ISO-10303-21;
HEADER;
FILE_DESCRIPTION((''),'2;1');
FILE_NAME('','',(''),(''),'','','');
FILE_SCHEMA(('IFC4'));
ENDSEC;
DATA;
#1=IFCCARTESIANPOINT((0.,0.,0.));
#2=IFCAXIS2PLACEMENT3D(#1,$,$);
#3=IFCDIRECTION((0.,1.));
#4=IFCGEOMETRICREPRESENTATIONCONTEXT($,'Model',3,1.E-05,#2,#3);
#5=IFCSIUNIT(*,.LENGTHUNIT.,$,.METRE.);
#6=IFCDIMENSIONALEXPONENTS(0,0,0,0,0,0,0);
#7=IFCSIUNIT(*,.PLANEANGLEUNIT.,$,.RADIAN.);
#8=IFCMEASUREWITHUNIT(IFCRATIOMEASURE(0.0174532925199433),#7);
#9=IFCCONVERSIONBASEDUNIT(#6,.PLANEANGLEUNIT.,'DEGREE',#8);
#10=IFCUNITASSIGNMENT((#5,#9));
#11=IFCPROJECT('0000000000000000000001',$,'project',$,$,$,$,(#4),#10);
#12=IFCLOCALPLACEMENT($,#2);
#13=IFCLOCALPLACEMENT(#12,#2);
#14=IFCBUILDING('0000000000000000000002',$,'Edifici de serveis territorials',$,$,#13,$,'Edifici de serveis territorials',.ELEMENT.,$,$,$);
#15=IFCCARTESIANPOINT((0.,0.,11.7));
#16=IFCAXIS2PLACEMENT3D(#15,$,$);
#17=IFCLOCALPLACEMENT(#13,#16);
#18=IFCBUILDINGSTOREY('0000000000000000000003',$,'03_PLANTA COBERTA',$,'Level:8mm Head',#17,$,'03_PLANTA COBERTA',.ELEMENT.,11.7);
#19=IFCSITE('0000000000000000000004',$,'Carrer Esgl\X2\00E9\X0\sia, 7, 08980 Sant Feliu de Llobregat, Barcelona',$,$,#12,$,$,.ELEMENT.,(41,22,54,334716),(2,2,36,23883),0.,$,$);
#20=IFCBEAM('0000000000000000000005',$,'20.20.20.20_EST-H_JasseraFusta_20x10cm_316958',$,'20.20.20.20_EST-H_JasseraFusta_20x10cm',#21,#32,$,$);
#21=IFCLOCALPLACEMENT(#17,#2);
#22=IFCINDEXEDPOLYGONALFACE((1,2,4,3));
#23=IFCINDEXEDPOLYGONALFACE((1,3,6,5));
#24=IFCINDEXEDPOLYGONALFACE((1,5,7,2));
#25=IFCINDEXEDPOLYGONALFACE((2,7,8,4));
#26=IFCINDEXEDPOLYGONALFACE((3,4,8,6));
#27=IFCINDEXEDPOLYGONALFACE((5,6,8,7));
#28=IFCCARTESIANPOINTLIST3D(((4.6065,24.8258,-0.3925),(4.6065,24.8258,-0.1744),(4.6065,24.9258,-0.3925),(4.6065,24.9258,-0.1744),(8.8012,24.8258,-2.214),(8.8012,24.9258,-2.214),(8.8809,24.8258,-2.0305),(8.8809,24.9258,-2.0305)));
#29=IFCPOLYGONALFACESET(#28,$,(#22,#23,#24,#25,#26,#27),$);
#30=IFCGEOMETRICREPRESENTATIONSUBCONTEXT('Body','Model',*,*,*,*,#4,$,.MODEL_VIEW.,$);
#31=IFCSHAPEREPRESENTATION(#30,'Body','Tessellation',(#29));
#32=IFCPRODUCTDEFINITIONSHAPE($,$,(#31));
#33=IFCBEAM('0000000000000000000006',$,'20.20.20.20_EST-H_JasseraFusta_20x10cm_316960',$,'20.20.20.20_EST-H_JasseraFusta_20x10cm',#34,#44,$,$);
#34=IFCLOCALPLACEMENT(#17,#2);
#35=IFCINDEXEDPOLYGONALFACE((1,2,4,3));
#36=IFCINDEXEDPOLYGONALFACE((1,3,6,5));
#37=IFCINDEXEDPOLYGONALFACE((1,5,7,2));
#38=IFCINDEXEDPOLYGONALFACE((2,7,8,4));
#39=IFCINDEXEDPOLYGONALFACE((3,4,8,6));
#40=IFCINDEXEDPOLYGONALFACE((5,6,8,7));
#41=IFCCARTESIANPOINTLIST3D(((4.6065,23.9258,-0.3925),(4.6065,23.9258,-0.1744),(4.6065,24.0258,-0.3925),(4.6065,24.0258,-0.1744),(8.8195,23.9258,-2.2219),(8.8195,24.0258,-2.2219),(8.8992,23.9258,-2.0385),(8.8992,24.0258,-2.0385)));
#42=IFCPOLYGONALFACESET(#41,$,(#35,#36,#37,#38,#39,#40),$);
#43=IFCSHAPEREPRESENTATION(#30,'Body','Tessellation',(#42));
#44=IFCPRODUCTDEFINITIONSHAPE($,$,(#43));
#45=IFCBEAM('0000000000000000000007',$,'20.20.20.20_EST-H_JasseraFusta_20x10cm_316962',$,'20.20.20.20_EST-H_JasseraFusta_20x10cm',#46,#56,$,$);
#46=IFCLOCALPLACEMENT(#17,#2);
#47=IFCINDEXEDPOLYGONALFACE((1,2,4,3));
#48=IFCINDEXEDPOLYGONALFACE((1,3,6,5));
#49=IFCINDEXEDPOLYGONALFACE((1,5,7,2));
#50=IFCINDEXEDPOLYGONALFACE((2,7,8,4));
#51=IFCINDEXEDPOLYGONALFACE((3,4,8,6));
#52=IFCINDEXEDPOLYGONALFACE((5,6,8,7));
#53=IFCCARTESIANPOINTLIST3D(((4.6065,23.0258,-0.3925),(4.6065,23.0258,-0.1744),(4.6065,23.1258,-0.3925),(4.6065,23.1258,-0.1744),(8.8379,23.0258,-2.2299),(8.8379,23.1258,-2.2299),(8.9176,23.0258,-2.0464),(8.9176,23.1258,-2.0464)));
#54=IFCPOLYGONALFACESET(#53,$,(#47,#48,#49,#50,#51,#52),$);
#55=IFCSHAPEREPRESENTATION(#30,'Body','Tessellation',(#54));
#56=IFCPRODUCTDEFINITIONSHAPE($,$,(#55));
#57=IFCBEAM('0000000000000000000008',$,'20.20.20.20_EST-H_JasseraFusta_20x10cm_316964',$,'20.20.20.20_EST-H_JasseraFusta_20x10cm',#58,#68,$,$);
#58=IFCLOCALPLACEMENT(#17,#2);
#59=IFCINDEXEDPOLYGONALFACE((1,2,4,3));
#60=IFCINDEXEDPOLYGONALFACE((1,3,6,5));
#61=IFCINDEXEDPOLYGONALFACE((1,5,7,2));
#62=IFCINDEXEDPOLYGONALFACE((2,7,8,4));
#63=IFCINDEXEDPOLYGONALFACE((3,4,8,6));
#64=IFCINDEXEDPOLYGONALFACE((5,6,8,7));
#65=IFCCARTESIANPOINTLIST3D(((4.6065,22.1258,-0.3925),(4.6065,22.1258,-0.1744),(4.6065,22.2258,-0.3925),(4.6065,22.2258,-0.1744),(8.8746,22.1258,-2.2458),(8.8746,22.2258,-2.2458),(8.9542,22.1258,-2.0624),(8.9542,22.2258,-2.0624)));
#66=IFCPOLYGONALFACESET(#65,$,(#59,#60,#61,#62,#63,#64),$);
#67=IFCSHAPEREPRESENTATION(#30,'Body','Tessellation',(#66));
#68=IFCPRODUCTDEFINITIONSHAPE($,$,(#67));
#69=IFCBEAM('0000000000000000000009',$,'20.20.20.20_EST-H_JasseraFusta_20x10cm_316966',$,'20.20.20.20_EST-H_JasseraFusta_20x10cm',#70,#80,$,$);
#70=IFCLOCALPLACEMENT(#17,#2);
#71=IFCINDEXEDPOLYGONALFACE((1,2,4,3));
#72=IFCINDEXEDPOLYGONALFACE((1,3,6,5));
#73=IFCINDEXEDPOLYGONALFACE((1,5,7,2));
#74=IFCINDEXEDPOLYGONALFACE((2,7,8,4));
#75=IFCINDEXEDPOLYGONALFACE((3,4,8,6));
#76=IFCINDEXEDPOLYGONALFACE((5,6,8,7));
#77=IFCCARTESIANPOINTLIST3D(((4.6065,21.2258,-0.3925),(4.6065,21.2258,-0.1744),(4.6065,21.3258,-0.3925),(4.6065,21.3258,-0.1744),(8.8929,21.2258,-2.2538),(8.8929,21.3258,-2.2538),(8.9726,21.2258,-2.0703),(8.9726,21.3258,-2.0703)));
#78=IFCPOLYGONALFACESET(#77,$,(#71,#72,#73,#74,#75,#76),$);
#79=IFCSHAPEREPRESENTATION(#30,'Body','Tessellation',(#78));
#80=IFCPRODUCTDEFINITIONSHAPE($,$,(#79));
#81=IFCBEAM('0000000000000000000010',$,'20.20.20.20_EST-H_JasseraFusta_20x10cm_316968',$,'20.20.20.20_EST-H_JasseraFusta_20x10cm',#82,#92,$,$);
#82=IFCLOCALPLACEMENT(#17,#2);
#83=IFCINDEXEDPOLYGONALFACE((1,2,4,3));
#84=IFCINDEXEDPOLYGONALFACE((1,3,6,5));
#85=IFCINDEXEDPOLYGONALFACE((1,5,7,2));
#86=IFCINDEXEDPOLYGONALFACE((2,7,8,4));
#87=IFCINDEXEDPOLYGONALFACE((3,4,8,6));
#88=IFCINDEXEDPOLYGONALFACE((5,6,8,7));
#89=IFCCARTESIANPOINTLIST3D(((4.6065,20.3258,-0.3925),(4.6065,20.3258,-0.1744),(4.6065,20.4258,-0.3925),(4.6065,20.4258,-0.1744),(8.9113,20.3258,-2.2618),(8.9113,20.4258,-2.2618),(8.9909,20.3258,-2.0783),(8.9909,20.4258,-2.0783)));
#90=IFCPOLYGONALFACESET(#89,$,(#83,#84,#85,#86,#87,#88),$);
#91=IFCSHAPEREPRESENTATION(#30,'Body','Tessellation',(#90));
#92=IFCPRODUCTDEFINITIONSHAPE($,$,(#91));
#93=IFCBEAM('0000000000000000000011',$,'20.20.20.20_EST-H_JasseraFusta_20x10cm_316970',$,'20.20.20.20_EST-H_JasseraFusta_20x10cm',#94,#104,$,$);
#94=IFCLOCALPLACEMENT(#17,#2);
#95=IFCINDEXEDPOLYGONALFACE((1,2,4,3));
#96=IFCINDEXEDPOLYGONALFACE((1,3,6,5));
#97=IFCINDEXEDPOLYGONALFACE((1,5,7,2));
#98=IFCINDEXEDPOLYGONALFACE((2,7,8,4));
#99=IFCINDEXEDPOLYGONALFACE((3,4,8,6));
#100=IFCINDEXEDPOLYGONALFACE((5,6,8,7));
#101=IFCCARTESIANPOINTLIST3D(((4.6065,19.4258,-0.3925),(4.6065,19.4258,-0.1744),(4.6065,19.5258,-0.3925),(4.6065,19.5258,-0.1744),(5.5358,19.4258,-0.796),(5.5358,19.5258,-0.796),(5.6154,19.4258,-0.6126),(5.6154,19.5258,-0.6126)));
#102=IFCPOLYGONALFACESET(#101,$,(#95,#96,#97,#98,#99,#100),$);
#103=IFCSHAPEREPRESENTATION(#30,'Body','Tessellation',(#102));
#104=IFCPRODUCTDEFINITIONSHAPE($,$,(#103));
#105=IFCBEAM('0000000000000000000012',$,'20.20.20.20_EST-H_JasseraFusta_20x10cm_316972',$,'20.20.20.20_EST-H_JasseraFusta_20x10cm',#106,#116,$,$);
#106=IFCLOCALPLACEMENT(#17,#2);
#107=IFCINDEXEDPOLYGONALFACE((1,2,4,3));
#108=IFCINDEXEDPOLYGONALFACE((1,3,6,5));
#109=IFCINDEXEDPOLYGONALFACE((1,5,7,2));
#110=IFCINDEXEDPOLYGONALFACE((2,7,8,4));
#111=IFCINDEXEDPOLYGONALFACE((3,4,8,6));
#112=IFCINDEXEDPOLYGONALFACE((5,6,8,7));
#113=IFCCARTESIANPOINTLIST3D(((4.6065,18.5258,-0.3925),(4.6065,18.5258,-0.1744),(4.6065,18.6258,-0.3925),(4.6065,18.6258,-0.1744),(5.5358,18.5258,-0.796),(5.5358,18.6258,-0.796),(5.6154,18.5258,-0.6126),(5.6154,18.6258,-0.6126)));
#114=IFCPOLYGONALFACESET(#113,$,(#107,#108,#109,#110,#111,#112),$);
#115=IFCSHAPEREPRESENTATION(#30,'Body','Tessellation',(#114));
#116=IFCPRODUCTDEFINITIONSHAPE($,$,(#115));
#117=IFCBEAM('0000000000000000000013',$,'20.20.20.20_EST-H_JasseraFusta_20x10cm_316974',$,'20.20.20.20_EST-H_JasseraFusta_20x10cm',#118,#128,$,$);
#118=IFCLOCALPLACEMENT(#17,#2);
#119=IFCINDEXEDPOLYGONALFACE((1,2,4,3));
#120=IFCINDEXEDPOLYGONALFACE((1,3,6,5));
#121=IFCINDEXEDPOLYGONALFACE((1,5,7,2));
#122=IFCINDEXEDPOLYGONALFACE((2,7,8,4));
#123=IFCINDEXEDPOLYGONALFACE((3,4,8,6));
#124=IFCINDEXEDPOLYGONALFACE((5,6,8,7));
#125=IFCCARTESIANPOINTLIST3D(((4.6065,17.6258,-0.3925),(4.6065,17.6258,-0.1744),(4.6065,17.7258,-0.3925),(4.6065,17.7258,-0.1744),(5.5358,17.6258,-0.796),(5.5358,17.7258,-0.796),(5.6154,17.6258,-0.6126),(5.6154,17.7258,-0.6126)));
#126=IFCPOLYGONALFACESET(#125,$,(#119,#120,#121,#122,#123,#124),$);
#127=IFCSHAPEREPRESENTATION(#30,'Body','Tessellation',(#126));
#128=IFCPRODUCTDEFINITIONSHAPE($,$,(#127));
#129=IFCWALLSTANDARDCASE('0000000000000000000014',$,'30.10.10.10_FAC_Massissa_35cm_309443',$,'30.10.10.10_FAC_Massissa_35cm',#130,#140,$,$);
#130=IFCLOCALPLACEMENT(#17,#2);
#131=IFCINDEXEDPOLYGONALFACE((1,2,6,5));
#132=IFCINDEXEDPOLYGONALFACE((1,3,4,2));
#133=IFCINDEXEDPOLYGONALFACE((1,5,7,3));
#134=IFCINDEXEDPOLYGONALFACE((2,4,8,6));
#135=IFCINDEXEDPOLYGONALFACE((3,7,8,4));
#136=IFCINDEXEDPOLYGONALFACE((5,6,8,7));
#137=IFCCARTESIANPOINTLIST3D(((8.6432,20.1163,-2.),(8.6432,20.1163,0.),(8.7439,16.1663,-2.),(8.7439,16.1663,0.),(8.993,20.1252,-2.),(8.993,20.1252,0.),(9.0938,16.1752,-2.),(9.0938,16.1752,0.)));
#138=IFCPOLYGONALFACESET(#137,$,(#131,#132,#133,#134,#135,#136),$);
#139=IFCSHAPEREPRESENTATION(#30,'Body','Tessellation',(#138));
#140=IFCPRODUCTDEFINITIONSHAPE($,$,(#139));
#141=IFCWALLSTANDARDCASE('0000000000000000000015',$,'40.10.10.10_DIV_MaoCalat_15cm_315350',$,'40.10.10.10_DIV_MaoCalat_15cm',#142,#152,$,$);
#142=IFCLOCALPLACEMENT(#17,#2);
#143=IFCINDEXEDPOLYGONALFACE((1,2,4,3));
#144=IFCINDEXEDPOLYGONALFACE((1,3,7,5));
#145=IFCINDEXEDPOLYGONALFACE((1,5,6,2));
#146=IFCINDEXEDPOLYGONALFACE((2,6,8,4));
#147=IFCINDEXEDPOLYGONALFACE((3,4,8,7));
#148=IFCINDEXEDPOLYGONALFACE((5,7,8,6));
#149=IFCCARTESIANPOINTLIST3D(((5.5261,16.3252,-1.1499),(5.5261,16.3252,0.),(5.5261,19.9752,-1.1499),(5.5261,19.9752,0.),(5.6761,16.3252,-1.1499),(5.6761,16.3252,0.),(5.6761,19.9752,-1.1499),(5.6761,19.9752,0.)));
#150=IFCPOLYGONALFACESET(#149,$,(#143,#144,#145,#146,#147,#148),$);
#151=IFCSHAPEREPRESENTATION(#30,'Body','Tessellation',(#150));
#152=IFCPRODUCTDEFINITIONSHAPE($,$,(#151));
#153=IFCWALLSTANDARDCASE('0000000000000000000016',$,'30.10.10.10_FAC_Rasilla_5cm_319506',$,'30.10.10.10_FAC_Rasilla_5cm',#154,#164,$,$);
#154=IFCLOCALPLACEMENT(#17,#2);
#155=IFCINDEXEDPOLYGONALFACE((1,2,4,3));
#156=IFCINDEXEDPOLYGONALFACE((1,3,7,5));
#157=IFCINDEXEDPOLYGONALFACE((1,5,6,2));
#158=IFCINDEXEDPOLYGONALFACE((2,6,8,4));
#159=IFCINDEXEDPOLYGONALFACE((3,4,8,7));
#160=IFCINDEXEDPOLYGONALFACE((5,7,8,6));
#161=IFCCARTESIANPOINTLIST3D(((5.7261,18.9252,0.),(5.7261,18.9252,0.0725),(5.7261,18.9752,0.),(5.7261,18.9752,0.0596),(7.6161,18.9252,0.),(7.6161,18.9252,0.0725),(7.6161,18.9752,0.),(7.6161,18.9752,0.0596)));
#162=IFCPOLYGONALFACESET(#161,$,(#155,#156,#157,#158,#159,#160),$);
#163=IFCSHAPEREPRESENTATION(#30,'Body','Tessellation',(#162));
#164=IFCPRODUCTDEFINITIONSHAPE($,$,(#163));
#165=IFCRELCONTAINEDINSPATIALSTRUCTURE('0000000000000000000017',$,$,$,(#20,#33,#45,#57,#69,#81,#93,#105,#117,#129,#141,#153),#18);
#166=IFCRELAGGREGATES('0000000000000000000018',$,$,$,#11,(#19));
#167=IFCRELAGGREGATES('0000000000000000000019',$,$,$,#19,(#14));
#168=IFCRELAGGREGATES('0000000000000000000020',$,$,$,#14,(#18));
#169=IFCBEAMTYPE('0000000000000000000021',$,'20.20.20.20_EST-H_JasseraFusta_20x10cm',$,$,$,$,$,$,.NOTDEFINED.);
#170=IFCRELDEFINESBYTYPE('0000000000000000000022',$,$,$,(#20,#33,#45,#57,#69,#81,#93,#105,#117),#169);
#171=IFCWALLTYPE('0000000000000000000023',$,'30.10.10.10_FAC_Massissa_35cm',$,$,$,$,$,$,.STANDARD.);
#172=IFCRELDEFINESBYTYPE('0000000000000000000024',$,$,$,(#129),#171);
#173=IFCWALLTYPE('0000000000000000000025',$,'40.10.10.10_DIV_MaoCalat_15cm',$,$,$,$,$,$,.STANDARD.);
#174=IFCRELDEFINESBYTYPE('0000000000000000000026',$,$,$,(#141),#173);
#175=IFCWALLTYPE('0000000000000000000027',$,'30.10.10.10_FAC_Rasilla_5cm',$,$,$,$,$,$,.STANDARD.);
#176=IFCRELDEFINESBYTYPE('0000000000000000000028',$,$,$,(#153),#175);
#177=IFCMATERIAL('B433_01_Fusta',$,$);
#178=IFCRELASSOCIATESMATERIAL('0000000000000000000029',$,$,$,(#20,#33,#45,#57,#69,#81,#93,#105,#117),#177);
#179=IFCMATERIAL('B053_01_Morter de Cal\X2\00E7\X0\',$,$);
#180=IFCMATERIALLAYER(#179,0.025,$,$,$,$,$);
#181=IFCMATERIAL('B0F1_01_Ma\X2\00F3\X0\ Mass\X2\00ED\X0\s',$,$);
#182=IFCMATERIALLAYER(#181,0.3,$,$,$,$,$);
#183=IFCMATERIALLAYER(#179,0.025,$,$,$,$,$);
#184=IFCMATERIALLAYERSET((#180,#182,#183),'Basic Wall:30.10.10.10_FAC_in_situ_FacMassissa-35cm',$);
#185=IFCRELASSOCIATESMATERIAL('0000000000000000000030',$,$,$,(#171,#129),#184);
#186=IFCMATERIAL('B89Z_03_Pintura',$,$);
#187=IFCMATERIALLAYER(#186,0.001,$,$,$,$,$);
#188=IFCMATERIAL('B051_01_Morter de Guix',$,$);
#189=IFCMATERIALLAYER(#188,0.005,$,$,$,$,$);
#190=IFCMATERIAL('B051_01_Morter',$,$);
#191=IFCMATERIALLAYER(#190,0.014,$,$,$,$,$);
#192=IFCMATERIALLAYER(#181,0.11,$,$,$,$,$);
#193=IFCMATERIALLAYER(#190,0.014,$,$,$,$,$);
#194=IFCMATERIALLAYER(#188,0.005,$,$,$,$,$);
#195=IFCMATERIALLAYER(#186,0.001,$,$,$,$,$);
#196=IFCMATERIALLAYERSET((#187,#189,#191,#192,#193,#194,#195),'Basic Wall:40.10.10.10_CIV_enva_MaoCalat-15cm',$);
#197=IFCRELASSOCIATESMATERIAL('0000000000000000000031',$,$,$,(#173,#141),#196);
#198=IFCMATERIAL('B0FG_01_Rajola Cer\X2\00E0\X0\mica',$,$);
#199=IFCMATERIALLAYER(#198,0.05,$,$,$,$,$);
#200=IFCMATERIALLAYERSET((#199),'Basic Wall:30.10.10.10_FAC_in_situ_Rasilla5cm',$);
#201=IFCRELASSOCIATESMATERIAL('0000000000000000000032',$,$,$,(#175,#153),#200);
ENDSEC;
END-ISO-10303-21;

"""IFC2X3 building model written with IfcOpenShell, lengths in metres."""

from ifc_helpers import new_model, entity, si_unit, converted_unit, direction, frame, frame_2d, origin, place, context, subcontext, project, spatial, polyline, rectangle, extrude, clip, halfspace, bounded_halfspace, material, layer, layer_set, layer_usage, type_object, element, save


model = new_model("IFC2X3")

# Units and contexts
model_context = context("Model", 3, precision=1e-05, world=origin(), true_north=direction((0.0, 1.0)))
body_context = subcontext(model_context, "Body", "Model", "MODEL_VIEW")
ifc_project = project(units=[si_unit("LENGTHUNIT", "METRE"), converted_unit("PLANEANGLEUNIT", "DEGREE", entity("IfcRatioMeasure", 0.0174532925199433), si_unit("PLANEANGLEUNIT", "RADIAN"), dimensions=[0, 0, 0, 0, 0, 0, 0])], contexts=[model_context])

# Site, building, storey
site_placement = place(None, origin())
site = spatial("IfcSite", under=ifc_project, at=site_placement, Name="Carrer Església, 7, 08980 Sant Feliu de Llobregat, Barcelona", CompositionType="ELEMENT", RefLatitude=(41, 22, 54, 334716), RefLongitude=(2, 2, 36, 23883), RefElevation=0.0)
building_placement = place(site_placement, origin())
building = spatial("IfcBuilding", under=site, at=building_placement, Name="Edifici de serveis territorials", LongName="Edifici de serveis territorials", CompositionType="ELEMENT")
storey_placement = place(building_placement, frame((0.0, 0.0, 11.7)))
storey = spatial("IfcBuildingStorey", under=building, at=storey_placement, Name="03_PLANTA COBERTA", ObjectType="Level:8mm Head", LongName="03_PLANTA COBERTA", CompositionType="ELEMENT", Elevation=11.7)

# Beams
ifc_material_1 = material(Name="B433_01_Fusta")
beam_type = type_object("IfcBeamType", Name="20.20.20.20_EST-H_JasseraFusta_20x10cm", PredefinedType="NOTDEFINED")
beam_1_placement = place(storey_placement, frame((4.6065, 24.8758, -0.1744), z_axis=(0.3983, 0.0, 0.917255), x_axis=(0.917255, 0.0, -0.3983)))
element("IfcBeam", 1, at=beam_1_placement, inside=storey, type_object=beam_type, material=ifc_material_1, Name="20.20.20.20_EST-H_JasseraFusta_20x10cm_316958", ObjectType="20.20.20.20_EST-H_JasseraFusta_20x10cm", context=body_context, shape_type="Clipping", body=[
    clip(extrude(rectangle(XDim=0.2, YDim=0.1, at=frame_2d((0.0, 0.0), x_axis=(1.0, 0.0))), frame((0.0, 0.0, -0.1), z_axis=(1.0, 0.0, 0.0), x_axis=(0.0, 0.0, -1.0)), (0.0, 0.0, 1.0), 4.66), halfspace(frame((0.0868, 0.0, -0.2), z_axis=(-0.917255, 0.0, -0.3983), x_axis=(0.0, 1.0, 0.0)), False)),
])
beam_2_placement = place(storey_placement, frame((4.6065, 23.9758, -0.1744), z_axis=(0.3983, 0.0, 0.917255), x_axis=(0.917255, 0.0, -0.3983)))
element("IfcBeam", 2, at=beam_2_placement, inside=storey, type_object=beam_type, material=ifc_material_1, Name="20.20.20.20_EST-H_JasseraFusta_20x10cm_316960", ObjectType="20.20.20.20_EST-H_JasseraFusta_20x10cm", context=body_context, shape_type="Clipping", body=[
    clip(extrude(rectangle(XDim=0.2, YDim=0.1, at=frame_2d((0.0, 0.0), x_axis=(1.0, 0.0))), frame((0.0, 0.0, -0.1), z_axis=(1.0, 0.0, 0.0), x_axis=(0.0, 0.0, -1.0)), (0.0, 0.0, 1.0), 4.68), halfspace(frame((0.0868, 0.0, -0.2), z_axis=(-0.917255, 0.0, -0.3983), x_axis=(0.0, 1.0, 0.0)), False)),
])
beam_3_placement = place(storey_placement, frame((4.6065, 23.0758, -0.1744), z_axis=(0.3983, 0.0, 0.917255), x_axis=(0.917255, 0.0, -0.3983)))
element("IfcBeam", 3, at=beam_3_placement, inside=storey, type_object=beam_type, material=ifc_material_1, Name="20.20.20.20_EST-H_JasseraFusta_20x10cm_316962", ObjectType="20.20.20.20_EST-H_JasseraFusta_20x10cm", context=body_context, shape_type="Clipping", body=[
    clip(extrude(rectangle(XDim=0.2, YDim=0.1, at=frame_2d((0.0, 0.0), x_axis=(1.0, 0.0))), frame((0.0, 0.0, -0.1), z_axis=(1.0, 0.0, 0.0), x_axis=(0.0, 0.0, -1.0)), (0.0, 0.0, 1.0), 4.7), halfspace(frame((0.0868, 0.0, -0.2), z_axis=(-0.917255, 0.0, -0.3983), x_axis=(0.0, 1.0, 0.0)), False)),
])
beam_4_placement = place(storey_placement, frame((4.6065, 22.1758, -0.1744), z_axis=(0.3983, 0.0, 0.917255), x_axis=(0.917255, 0.0, -0.3983)))
element("IfcBeam", 4, at=beam_4_placement, inside=storey, type_object=beam_type, material=ifc_material_1, Name="20.20.20.20_EST-H_JasseraFusta_20x10cm_316964", ObjectType="20.20.20.20_EST-H_JasseraFusta_20x10cm", context=body_context, shape_type="Clipping", body=[
    clip(extrude(rectangle(XDim=0.2, YDim=0.1, at=frame_2d((0.0, 0.0), x_axis=(1.0, 0.0))), frame((0.0, 0.0, -0.1), z_axis=(1.0, 0.0, 0.0), x_axis=(0.0, 0.0, -1.0)), (0.0, 0.0, 1.0), 4.74), halfspace(frame((0.0868, 0.0, -0.2), z_axis=(-0.917255, 0.0, -0.3983), x_axis=(0.0, 1.0, 0.0)), False)),
])
beam_5_placement = place(storey_placement, frame((4.6065, 21.2758, -0.1744), z_axis=(0.3983, 0.0, 0.917255), x_axis=(0.917255, 0.0, -0.3983)))
element("IfcBeam", 5, at=beam_5_placement, inside=storey, type_object=beam_type, material=ifc_material_1, Name="20.20.20.20_EST-H_JasseraFusta_20x10cm_316966", ObjectType="20.20.20.20_EST-H_JasseraFusta_20x10cm", context=body_context, shape_type="Clipping", body=[
    clip(extrude(rectangle(XDim=0.2, YDim=0.1, at=frame_2d((0.0, 0.0), x_axis=(1.0, 0.0))), frame((0.0, 0.0, -0.1), z_axis=(1.0, 0.0, 0.0), x_axis=(0.0, 0.0, -1.0)), (0.0, 0.0, 1.0), 4.76), halfspace(frame((0.0868, 0.0, -0.2), z_axis=(-0.917255, 0.0, -0.3983), x_axis=(0.0, 1.0, 0.0)), False)),
])
beam_6_placement = place(storey_placement, frame((4.6065, 20.3758, -0.1744), z_axis=(0.3983, 0.0, 0.917255), x_axis=(0.917255, 0.0, -0.3983)))
element("IfcBeam", 6, at=beam_6_placement, inside=storey, type_object=beam_type, material=ifc_material_1, Name="20.20.20.20_EST-H_JasseraFusta_20x10cm_316968", ObjectType="20.20.20.20_EST-H_JasseraFusta_20x10cm", context=body_context, shape_type="Clipping", body=[
    clip(extrude(rectangle(XDim=0.2, YDim=0.1, at=frame_2d((0.0, 0.0), x_axis=(1.0, 0.0))), frame((0.0, 0.0, -0.1), z_axis=(1.0, 0.0, 0.0), x_axis=(0.0, 0.0, -1.0)), (0.0, 0.0, 1.0), 4.78), halfspace(frame((0.0868, 0.0, -0.2), z_axis=(-0.917255, 0.0, -0.3983), x_axis=(0.0, 1.0, 0.0)), False)),
])
beam_7_placement = place(storey_placement, frame((4.6065, 19.4758, -0.1744), z_axis=(0.3983, 0.0, 0.917255), x_axis=(0.917255, 0.0, -0.3983)))
element("IfcBeam", 7, at=beam_7_placement, inside=storey, type_object=beam_type, material=ifc_material_1, Name="20.20.20.20_EST-H_JasseraFusta_20x10cm_316970", ObjectType="20.20.20.20_EST-H_JasseraFusta_20x10cm", context=body_context, shape_type="Clipping", body=[
    clip(extrude(rectangle(XDim=0.2, YDim=0.1, at=frame_2d((0.0, 0.0), x_axis=(1.0, 0.0))), frame((0.0, 0.0, -0.1), z_axis=(1.0, 0.0, 0.0), x_axis=(0.0, 0.0, -1.0)), (0.0, 0.0, 1.0), 1.1), halfspace(frame((0.0868, 0.0, -0.2), z_axis=(-0.917255, 0.0, -0.3983), x_axis=(0.0, 1.0, 0.0)), False)),
])
beam_8_placement = place(storey_placement, frame((4.6065, 18.5758, -0.1744), z_axis=(0.3983, 0.0, 0.917255), x_axis=(0.917255, 0.0, -0.3983)))
element("IfcBeam", 8, at=beam_8_placement, inside=storey, type_object=beam_type, material=ifc_material_1, Name="20.20.20.20_EST-H_JasseraFusta_20x10cm_316972", ObjectType="20.20.20.20_EST-H_JasseraFusta_20x10cm", context=body_context, shape_type="Clipping", body=[
    clip(extrude(rectangle(XDim=0.2, YDim=0.1, at=frame_2d((0.0, 0.0), x_axis=(1.0, 0.0))), frame((0.0, 0.0, -0.1), z_axis=(1.0, 0.0, 0.0), x_axis=(0.0, 0.0, -1.0)), (0.0, 0.0, 1.0), 1.1), halfspace(frame((0.0868, 0.0, -0.2), z_axis=(-0.917255, 0.0, -0.3983), x_axis=(0.0, 1.0, 0.0)), False)),
])
beam_9_placement = place(storey_placement, frame((4.6065, 17.6758, -0.1744), z_axis=(0.3983, 0.0, 0.917255), x_axis=(0.917255, 0.0, -0.3983)))
element("IfcBeam", 9, at=beam_9_placement, inside=storey, type_object=beam_type, material=ifc_material_1, Name="20.20.20.20_EST-H_JasseraFusta_20x10cm_316974", ObjectType="20.20.20.20_EST-H_JasseraFusta_20x10cm", context=body_context, shape_type="Clipping", body=[
    clip(extrude(rectangle(XDim=0.2, YDim=0.1, at=frame_2d((0.0, 0.0), x_axis=(1.0, 0.0))), frame((0.0, 0.0, -0.1), z_axis=(1.0, 0.0, 0.0), x_axis=(0.0, 0.0, -1.0)), (0.0, 0.0, 1.0), 1.1), halfspace(frame((0.0868, 0.0, -0.2), z_axis=(-0.917255, 0.0, -0.3983), x_axis=(0.0, 1.0, 0.0)), False)),
])

# Walls
ifc_material_2 = material(Name="B053_01_Morter de Calç")
ifc_layer_1 = layer(ifc_material_2, 0.025)
ifc_material_3 = material(Name="B0F1_01_Maó Massís")
ifc_layer_2 = layer(ifc_material_3, 0.3)
ifc_layer_3 = layer(ifc_material_2, 0.025)
ifc_layer_set_1 = layer_set([ifc_layer_1, ifc_layer_2, ifc_layer_3], Name="Basic Wall:30.10.10.10_FAC_in_situ_FacMassissa-35cm")
ifc_layer_usage_1 = layer_usage(ifc_layer_set_1, "AXIS2", "NEGATIVE", 0.175)
wall_type_1 = type_object("IfcWallType", Name="30.10.10.10_FAC_Massissa_35cm", PredefinedType="STANDARD", material=ifc_layer_set_1)
wall_1_placement = place(storey_placement, frame((8.8181, 20.1207, -2.0), z_axis=(0.0, 0.0, 1.0), x_axis=(0.025497, -0.999675, 0.0)))
element("IfcWallStandardCase", 10, at=wall_1_placement, inside=storey, type_object=wall_type_1, material=ifc_layer_usage_1, Name="30.10.10.10_FAC_Massissa_35cm_309443", ObjectType="30.10.10.10_FAC_Massissa_35cm", context=body_context, shape_type="SweptSolid", body=[
    extrude(rectangle(XDim=3.9513, YDim=0.35, at=frame_2d((1.9756, 0.0), x_axis=(-1.0, 0.0))), origin(), (0.0, 0.0, 1.0), 2.0),
])
ifc_material_4 = material(Name="B89Z_03_Pintura")
ifc_layer_4 = layer(ifc_material_4, 0.001)
ifc_material_5 = material(Name="B051_01_Morter de Guix")
ifc_layer_5 = layer(ifc_material_5, 0.005)
ifc_material_6 = material(Name="B051_01_Morter")
ifc_layer_6 = layer(ifc_material_6, 0.014)
ifc_layer_7 = layer(ifc_material_3, 0.11)
ifc_layer_8 = layer(ifc_material_6, 0.014)
ifc_layer_9 = layer(ifc_material_5, 0.005)
ifc_layer_10 = layer(ifc_material_4, 0.001)
ifc_layer_set_2 = layer_set([ifc_layer_4, ifc_layer_5, ifc_layer_6, ifc_layer_7, ifc_layer_8, ifc_layer_9, ifc_layer_10], Name="Basic Wall:40.10.10.10_CIV_enva_MaoCalat-15cm")
ifc_layer_usage_2 = layer_usage(ifc_layer_set_2, "AXIS2", "NEGATIVE", 0.075)
wall_type_2 = type_object("IfcWallType", Name="40.10.10.10_DIV_MaoCalat_15cm", PredefinedType="STANDARD", material=ifc_layer_set_2)
wall_2_placement = place(storey_placement, frame((5.6011, 19.9752, -1.1499), z_axis=(0.0, 0.0, 1.0), x_axis=(0.0, -1.0, 0.0)))
element("IfcWallStandardCase", 11, at=wall_2_placement, inside=storey, type_object=wall_type_2, material=ifc_layer_usage_2, Name="40.10.10.10_DIV_MaoCalat_15cm_315350", ObjectType="40.10.10.10_DIV_MaoCalat_15cm", context=body_context, shape_type="SweptSolid", body=[
    extrude(rectangle(XDim=3.65, YDim=0.15, at=frame_2d((1.825, 0.0), x_axis=(-1.0, 0.0))), origin(), (0.0, 0.0, 1.0), 1.1499),
])
ifc_material_7 = material(Name="B0FG_01_Rajola Ceràmica")
ifc_layer_11 = layer(ifc_material_7, 0.05)
ifc_layer_set_3 = layer_set([ifc_layer_11], Name="Basic Wall:30.10.10.10_FAC_in_situ_Rasilla5cm")
ifc_layer_usage_3 = layer_usage(ifc_layer_set_3, "AXIS2", "NEGATIVE", 0.025)
wall_type_3 = type_object("IfcWallType", Name="30.10.10.10_FAC_Rasilla_5cm", PredefinedType="STANDARD", material=ifc_layer_set_3)
wall_3_placement = place(storey_placement, frame((5.7261, 18.9502, 0.0)))
element("IfcWallStandardCase", 12, at=wall_3_placement, inside=storey, type_object=wall_type_3, material=ifc_layer_usage_3, Name="30.10.10.10_FAC_Rasilla_5cm_319506", ObjectType="30.10.10.10_FAC_Rasilla_5cm", context=body_context, shape_type="Clipping", body=[
    clip(extrude(rectangle(XDim=1.89, YDim=0.05, at=frame_2d((0.945, 0.0), x_axis=(-1.0, 0.0))), origin(), (0.0, 0.0, 1.0), 0.0725), bounded_halfspace(frame((0.0, -0.025, 0.0725), z_axis=(0.0, -0.249878, -0.968277), x_axis=(1.0, 0.0, 0.0)), True, frame((0.0, -0.025, 0.0725)), polyline([(0.0, 0.0), (0.05, 0.0), (1.89, 0.0), (1.89, 0.05), (0.0, 0.05), (0.0, 0.0)]))),
])

save(model, "model.ifc")
